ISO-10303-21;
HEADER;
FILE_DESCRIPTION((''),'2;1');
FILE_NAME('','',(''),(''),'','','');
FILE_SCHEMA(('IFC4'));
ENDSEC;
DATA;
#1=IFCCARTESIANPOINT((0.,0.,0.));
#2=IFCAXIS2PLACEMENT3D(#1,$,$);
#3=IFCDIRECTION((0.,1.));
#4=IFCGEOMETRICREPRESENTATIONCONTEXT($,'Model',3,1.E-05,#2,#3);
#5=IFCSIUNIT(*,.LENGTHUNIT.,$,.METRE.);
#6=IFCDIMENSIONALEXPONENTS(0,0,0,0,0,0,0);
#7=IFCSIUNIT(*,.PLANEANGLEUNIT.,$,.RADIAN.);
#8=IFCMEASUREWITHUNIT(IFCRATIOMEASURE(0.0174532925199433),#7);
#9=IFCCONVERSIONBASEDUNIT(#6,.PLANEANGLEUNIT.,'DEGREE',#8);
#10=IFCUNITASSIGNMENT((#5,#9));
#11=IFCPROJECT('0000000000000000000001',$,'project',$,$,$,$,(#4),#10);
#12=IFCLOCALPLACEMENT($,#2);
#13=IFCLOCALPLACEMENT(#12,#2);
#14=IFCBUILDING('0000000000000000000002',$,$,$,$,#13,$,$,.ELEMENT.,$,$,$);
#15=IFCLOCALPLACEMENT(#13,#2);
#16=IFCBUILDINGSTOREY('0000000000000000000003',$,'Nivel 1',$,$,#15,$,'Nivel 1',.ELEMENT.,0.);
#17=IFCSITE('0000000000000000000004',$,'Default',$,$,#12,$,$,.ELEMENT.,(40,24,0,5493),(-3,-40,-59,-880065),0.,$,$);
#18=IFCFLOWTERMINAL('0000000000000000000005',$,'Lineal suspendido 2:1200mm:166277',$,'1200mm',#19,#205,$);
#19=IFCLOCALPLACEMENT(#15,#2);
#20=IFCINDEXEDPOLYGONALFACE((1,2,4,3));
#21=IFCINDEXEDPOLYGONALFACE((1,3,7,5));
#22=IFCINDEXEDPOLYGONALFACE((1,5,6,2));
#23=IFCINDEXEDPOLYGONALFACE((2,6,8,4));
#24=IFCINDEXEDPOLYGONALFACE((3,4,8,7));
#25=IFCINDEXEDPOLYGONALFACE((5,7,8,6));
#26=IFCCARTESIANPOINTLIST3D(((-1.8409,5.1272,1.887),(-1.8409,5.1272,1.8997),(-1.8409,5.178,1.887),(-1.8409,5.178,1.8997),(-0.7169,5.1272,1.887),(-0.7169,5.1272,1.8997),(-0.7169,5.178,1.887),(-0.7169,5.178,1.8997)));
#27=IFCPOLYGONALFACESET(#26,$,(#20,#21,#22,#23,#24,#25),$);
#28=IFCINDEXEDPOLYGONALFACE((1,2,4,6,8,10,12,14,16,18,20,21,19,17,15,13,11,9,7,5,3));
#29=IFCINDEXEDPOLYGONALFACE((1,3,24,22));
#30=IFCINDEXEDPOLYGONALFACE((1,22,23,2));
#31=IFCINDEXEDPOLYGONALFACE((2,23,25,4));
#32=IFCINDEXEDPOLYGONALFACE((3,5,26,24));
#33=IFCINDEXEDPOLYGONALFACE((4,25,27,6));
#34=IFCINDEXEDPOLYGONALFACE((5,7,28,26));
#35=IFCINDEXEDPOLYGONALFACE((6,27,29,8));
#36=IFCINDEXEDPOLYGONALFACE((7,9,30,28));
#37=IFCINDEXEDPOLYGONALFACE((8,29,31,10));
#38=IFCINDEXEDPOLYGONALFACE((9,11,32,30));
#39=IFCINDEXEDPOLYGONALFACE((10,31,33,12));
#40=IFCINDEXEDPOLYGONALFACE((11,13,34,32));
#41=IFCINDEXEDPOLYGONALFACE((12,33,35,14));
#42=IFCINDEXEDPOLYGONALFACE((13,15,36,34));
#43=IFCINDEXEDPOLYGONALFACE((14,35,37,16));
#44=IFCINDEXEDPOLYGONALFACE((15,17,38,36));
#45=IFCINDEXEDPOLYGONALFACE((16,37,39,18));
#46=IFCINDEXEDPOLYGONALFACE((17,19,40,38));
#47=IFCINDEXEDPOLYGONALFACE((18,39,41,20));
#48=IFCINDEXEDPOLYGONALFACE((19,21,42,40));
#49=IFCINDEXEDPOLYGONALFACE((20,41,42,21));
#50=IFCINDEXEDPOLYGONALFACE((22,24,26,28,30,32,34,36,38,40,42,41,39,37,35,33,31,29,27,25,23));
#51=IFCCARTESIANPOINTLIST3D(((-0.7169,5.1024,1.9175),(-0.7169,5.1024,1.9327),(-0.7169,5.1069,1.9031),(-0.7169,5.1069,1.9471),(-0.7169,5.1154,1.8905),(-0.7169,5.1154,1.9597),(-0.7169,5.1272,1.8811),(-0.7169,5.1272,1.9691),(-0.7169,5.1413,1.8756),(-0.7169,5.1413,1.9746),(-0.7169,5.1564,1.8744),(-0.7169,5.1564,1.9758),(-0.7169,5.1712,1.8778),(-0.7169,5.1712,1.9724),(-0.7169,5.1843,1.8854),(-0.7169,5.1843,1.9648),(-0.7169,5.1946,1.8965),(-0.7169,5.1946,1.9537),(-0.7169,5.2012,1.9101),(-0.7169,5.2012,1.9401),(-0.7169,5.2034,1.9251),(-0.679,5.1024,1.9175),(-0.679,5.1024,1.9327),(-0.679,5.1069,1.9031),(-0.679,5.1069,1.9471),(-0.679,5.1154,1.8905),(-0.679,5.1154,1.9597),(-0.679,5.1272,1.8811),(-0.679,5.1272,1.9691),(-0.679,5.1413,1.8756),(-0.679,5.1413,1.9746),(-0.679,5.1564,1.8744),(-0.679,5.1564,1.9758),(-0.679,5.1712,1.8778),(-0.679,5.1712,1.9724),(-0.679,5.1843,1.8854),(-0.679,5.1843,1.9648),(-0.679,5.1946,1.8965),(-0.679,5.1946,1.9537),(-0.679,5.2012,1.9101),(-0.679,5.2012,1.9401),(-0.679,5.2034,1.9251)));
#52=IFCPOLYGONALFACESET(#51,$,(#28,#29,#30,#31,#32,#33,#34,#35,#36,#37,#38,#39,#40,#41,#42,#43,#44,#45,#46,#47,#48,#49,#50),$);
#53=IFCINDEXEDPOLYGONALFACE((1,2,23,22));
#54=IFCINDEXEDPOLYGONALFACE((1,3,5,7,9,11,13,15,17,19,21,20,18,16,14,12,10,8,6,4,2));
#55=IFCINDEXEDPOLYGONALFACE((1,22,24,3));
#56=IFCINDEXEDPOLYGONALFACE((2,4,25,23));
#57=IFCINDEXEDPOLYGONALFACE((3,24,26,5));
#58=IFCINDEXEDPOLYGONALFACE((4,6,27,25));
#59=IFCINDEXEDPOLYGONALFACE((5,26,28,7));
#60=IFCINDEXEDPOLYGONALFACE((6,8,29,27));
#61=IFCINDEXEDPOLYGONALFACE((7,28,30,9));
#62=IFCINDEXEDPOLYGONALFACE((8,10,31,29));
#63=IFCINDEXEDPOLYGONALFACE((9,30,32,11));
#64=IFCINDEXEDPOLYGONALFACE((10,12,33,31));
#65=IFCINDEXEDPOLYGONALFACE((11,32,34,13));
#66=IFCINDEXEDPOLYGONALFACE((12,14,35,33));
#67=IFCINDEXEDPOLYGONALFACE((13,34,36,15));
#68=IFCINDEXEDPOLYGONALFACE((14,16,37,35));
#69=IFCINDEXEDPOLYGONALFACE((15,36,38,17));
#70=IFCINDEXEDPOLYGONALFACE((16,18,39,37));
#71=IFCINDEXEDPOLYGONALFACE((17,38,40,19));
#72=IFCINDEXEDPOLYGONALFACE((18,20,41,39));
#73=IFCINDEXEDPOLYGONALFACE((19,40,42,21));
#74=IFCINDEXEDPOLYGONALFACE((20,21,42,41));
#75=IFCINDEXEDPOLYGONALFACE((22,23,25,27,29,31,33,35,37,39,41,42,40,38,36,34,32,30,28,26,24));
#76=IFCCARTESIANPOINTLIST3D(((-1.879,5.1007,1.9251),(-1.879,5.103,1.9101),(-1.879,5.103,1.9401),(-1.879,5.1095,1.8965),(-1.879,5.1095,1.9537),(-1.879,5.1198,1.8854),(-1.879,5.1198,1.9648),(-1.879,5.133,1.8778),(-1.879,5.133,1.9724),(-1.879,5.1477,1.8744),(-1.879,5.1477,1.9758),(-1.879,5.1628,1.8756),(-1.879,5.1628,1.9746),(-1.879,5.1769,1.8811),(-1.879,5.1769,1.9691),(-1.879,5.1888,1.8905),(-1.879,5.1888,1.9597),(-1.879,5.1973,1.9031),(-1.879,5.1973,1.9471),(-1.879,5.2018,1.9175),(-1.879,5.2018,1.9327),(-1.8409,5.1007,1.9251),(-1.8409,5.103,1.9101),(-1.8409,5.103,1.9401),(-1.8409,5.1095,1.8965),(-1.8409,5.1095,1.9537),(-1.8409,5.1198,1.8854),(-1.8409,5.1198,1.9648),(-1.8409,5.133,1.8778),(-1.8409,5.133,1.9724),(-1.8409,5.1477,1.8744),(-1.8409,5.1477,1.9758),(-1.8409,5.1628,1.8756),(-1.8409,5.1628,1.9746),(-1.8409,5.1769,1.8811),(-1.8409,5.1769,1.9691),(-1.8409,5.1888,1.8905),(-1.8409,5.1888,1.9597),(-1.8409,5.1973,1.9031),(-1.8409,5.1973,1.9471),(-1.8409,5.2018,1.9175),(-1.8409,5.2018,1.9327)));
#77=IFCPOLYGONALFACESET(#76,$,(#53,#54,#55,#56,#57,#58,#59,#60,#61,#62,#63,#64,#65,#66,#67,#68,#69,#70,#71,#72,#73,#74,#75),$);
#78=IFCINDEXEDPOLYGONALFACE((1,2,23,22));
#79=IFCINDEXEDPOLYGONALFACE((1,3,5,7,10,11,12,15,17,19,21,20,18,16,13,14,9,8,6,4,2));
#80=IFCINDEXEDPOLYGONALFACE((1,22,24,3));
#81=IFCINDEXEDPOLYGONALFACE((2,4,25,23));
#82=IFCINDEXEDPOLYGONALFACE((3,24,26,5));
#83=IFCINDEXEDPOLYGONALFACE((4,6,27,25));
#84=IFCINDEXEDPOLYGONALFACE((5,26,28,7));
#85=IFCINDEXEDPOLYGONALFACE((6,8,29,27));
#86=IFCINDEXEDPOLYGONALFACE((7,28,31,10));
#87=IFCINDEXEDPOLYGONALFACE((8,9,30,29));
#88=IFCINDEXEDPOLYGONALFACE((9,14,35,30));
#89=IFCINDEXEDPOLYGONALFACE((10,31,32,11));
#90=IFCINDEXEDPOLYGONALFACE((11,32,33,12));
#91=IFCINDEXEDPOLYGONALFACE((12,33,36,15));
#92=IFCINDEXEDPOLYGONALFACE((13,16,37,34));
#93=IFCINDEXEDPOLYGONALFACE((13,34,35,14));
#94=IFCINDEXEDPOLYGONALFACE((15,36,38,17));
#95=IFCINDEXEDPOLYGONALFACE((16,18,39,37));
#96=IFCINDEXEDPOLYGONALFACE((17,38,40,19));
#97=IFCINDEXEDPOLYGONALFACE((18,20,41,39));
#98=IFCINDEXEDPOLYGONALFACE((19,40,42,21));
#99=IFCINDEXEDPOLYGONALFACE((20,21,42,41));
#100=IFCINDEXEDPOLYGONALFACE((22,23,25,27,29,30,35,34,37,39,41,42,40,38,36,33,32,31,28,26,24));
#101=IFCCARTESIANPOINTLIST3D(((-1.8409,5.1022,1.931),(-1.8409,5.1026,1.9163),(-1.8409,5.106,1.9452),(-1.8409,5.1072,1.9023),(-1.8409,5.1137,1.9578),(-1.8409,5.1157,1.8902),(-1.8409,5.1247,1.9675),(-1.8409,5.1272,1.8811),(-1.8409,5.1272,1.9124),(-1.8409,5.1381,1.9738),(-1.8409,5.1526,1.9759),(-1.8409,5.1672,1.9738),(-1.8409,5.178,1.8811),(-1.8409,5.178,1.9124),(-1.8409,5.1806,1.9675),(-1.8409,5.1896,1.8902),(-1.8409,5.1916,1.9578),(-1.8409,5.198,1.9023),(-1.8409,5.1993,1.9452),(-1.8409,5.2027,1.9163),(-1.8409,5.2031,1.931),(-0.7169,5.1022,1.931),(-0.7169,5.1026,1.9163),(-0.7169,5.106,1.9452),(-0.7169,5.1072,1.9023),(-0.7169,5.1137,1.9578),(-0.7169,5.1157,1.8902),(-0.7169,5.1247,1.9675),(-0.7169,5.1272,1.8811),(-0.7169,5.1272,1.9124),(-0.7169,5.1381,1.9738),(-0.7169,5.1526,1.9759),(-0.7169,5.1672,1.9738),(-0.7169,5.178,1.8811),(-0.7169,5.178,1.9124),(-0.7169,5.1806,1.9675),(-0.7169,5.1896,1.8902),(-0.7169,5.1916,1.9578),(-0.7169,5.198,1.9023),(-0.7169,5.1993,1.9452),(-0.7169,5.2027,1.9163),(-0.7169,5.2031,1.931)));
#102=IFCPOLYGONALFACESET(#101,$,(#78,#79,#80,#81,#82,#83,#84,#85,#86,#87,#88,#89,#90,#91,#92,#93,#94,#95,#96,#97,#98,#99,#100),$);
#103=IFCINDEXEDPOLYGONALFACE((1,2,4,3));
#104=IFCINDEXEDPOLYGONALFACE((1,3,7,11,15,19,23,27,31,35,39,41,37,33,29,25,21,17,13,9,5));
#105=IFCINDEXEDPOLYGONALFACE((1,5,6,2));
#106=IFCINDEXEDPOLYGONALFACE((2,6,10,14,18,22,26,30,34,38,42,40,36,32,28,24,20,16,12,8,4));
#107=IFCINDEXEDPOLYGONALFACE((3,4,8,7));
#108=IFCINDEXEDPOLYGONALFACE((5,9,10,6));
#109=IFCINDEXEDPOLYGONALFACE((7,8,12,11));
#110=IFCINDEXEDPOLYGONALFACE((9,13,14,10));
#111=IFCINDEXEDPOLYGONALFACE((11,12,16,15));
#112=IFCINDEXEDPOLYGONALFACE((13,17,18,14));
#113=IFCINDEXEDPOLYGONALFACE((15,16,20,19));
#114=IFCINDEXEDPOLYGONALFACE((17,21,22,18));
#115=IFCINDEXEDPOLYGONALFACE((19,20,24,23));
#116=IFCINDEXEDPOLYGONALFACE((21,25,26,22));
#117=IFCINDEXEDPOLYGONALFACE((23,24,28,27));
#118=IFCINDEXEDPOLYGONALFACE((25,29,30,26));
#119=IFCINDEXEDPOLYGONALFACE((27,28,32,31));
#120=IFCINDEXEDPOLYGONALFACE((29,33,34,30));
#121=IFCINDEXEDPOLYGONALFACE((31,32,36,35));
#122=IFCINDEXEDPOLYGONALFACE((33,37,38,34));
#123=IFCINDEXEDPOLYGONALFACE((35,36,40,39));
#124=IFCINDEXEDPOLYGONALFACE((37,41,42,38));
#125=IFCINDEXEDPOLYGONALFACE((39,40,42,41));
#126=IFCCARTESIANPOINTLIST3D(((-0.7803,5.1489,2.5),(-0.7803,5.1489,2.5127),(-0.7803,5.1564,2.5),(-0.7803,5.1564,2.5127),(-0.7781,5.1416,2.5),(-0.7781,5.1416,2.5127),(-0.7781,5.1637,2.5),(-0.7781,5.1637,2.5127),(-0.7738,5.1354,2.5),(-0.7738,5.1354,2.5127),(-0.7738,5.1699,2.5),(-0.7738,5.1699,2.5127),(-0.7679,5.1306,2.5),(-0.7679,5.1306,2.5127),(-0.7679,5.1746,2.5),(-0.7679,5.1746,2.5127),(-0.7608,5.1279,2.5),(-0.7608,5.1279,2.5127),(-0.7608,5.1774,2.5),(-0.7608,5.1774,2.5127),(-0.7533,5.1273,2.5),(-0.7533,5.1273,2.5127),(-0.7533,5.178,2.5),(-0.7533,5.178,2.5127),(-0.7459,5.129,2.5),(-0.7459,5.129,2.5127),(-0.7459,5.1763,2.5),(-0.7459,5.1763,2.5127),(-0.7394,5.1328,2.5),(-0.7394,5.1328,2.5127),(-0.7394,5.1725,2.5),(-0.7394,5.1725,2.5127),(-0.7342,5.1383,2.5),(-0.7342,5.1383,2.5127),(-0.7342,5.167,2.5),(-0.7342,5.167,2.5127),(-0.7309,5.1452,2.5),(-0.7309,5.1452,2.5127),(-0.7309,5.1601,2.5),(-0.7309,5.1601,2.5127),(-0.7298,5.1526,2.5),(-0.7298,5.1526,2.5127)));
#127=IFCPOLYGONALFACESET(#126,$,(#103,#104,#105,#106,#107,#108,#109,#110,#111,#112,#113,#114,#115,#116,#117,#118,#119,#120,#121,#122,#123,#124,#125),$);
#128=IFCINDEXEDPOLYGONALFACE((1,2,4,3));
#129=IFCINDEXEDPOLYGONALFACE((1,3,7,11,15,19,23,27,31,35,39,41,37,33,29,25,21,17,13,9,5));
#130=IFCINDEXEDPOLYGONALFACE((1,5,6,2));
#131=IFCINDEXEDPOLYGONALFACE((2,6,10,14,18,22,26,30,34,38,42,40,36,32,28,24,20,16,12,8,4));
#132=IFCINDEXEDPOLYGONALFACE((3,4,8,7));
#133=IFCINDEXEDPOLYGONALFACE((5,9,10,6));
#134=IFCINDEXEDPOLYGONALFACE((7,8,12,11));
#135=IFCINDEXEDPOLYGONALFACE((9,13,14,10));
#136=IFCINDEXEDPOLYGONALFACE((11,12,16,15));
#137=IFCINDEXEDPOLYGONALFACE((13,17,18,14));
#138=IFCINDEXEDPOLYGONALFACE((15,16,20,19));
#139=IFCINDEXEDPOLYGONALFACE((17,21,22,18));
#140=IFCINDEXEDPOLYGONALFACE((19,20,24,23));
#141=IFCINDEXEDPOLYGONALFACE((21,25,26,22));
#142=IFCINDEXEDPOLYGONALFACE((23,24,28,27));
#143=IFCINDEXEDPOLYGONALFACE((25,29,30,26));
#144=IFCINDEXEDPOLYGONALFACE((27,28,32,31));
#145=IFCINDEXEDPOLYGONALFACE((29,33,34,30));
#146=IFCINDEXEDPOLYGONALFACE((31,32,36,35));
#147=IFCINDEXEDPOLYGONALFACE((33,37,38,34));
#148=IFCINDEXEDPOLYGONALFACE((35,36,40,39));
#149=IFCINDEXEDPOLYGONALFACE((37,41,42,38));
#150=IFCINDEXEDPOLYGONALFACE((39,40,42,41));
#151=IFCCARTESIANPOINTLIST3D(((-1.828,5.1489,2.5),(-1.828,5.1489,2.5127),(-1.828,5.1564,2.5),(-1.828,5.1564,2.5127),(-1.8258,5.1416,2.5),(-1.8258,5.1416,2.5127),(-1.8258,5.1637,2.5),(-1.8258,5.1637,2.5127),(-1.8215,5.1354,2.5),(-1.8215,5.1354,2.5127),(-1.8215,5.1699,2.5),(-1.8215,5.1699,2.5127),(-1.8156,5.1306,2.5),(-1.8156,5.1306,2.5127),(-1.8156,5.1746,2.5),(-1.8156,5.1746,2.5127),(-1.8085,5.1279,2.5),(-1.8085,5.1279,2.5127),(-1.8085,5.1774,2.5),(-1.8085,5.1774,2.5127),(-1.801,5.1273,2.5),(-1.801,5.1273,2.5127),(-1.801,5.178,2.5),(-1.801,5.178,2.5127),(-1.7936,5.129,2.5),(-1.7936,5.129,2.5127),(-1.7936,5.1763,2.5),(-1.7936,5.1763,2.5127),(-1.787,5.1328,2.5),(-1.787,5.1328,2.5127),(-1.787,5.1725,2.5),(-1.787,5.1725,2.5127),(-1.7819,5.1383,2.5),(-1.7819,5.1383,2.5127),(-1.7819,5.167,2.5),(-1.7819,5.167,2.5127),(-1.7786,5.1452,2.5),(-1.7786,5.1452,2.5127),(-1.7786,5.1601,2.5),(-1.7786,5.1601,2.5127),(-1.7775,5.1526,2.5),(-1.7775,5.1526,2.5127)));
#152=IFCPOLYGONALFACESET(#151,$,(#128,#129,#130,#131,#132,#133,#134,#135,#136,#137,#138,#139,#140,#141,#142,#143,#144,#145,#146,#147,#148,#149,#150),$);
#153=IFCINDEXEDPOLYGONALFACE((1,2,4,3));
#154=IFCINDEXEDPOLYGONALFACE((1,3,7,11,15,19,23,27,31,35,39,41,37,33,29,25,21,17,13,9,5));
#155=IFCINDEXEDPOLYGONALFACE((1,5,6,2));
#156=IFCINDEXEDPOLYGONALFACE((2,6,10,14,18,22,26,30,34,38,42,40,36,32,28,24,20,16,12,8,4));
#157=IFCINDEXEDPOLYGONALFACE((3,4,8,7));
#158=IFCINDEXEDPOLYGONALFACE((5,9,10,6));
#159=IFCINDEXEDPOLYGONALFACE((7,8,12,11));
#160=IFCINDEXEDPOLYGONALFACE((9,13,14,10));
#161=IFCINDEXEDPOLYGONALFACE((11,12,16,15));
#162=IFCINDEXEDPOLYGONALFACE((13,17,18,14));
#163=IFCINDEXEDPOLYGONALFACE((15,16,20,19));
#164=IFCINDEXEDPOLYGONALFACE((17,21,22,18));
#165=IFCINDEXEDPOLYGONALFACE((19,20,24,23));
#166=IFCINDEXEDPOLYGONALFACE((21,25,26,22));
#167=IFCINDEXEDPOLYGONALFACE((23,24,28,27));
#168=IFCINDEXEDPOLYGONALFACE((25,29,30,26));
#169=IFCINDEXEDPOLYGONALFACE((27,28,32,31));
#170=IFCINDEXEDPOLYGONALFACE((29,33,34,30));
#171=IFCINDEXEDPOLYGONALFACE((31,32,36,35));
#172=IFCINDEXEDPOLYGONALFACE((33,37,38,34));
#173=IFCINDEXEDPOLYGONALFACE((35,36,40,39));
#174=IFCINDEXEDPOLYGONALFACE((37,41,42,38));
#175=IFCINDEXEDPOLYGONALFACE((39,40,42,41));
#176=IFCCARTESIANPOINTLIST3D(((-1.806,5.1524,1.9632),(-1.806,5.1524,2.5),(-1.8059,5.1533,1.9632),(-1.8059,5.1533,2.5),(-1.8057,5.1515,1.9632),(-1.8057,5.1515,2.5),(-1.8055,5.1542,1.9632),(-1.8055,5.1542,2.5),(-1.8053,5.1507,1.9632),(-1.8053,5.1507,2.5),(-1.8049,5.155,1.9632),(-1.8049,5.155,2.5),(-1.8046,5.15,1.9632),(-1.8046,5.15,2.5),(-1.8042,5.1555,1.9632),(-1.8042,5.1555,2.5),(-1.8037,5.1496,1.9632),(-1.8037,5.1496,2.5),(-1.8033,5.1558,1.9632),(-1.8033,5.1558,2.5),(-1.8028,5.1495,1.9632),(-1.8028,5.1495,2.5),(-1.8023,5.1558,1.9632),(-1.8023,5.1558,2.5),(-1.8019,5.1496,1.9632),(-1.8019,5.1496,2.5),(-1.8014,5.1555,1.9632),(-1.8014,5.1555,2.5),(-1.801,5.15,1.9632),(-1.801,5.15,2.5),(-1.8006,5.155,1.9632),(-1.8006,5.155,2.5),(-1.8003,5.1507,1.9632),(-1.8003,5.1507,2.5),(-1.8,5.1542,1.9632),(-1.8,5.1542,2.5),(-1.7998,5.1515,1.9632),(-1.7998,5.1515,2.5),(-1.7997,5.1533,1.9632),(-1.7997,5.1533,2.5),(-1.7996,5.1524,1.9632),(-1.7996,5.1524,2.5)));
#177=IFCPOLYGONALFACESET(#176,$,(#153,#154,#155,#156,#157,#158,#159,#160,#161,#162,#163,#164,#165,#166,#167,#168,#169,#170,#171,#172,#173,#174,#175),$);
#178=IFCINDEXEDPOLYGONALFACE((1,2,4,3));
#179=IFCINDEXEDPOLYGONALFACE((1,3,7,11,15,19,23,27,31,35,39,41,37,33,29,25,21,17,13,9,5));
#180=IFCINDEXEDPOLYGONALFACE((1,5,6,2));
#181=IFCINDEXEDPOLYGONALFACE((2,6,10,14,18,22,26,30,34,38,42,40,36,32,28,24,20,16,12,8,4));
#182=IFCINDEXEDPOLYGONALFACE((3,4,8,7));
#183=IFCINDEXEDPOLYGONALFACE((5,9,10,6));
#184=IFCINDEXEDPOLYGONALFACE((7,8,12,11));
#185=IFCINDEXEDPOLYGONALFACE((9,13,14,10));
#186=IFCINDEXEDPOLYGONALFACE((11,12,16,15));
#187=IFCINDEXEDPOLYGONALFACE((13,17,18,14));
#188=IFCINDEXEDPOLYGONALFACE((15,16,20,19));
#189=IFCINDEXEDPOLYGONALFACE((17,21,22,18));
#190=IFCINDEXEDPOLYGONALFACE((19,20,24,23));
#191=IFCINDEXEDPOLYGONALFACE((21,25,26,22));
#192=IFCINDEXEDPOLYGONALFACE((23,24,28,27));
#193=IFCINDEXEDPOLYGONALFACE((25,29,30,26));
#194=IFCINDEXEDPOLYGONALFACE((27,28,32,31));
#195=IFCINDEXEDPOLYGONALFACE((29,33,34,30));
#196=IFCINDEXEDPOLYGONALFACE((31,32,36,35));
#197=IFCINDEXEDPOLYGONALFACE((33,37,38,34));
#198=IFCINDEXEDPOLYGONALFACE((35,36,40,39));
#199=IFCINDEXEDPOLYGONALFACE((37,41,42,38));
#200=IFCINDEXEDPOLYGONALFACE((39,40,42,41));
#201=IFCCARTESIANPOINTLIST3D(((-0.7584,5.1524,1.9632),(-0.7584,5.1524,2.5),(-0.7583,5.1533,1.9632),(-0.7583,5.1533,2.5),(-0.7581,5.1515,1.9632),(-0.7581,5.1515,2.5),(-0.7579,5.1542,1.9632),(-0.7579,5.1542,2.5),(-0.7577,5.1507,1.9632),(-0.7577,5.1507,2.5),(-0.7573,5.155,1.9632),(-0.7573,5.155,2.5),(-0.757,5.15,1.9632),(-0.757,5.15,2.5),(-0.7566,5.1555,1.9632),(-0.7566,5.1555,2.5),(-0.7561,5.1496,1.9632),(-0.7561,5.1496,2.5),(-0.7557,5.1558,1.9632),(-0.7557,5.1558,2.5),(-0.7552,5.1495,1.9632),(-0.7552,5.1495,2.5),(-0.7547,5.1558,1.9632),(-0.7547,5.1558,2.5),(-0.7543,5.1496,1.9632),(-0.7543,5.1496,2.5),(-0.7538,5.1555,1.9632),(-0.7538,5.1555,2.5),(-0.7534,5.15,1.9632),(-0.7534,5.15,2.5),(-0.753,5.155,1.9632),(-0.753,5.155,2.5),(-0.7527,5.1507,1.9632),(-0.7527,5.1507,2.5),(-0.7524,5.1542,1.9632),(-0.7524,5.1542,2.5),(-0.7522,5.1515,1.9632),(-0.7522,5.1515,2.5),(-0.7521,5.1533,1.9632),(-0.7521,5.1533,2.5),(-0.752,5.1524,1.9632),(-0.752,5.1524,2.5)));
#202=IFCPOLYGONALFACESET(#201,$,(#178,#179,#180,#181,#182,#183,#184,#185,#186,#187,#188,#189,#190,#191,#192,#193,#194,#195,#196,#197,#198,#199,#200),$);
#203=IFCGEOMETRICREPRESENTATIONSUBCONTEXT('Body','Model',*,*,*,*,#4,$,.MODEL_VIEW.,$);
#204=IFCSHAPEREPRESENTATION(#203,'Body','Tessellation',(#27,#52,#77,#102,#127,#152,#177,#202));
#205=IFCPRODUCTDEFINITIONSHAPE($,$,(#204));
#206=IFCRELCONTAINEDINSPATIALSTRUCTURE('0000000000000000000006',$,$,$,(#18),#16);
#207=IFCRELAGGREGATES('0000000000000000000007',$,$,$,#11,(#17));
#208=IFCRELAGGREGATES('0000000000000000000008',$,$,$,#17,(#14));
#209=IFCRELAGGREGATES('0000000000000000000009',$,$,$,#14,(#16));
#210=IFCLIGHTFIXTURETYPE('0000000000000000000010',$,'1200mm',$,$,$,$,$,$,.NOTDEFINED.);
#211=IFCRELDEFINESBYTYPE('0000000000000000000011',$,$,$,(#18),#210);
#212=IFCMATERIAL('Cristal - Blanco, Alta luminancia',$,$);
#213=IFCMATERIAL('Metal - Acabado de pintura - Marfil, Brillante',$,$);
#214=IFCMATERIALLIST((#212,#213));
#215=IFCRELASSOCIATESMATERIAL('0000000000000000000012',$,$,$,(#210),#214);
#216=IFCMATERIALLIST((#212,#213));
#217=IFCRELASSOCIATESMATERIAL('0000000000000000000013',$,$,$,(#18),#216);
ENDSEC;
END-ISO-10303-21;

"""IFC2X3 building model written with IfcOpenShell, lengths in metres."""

from ifc_helpers import new_model, entity, si_unit, converted_unit, direction, frame, frame_2d, origin, origin_2d_with_axis, place, context, subcontext, project, spatial, polyline, circle_curve, parameter, trimmed, segment, composite_curve, rectangle, circle, outline, extrude, source, transform, mapped, material, material_list, type_object, type_shapes, element, save


model = new_model("IFC2X3")

# Units and contexts
model_context = context("Model", 3, precision=1e-05, world=origin(), true_north=direction((0.0, 1.0)))
body_context = subcontext(model_context, "Body", "Model", "MODEL_VIEW")
ifc_project = project(units=[si_unit("LENGTHUNIT", "METRE"), converted_unit("PLANEANGLEUNIT", "DEGREE", entity("IfcRatioMeasure", 0.0174532925199433), si_unit("PLANEANGLEUNIT", "RADIAN"), dimensions=[0, 0, 0, 0, 0, 0, 0])], contexts=[model_context])

# Site, building, storey
site_placement = place(None, origin())
site = spatial("IfcSite", under=ifc_project, at=site_placement, Name="Default", CompositionType="ELEMENT", RefLatitude=(40, 24, 0, 5493), RefLongitude=(-3, -40, -59, -880065), RefElevation=0.0)
building_placement = place(site_placement, origin())
building = spatial("IfcBuilding", under=site, at=building_placement, CompositionType="ELEMENT")
storey_placement = place(building_placement, origin())
storey = spatial("IfcBuildingStorey", under=building, at=storey_placement, Name="Nivel 1", LongName="Nivel 1", CompositionType="ELEMENT", Elevation=0.0)

# Flow terminal
ifc_material_1 = material(Name="Cristal - Blanco, Alta luminancia")
ifc_material_2 = material(Name="Metal - Acabado de pintura - Marfil, Brillante")
ifc_material_list_1 = material_list([ifc_material_1, ifc_material_2])
ifc_material_list_2 = material_list([ifc_material_1, ifc_material_2])
light_fixture_type = type_object("IfcLightFixtureType", Name="1200mm", PredefinedType="NOTDEFINED", material=ifc_material_list_2)
shared_shape = source(origin(), body_context, "Body", "SweptSolid", [
    extrude(rectangle(XDim=1.124, YDim=0.0508, at=origin_2d_with_axis()), frame((0.0001, 0.0, 1.8127), z_axis=(0.0, 0.0, 1.0), x_axis=(-1.0, 0.0, 0.0)), (0.0, 0.0, 1.0), 0.0127),
    extrude(circle(Radius=0.0508, at=frame_2d((0.0, 0.0), x_axis=(1.0, 0.0))), frame((0.5621, 0.0, 1.8508), z_axis=(1.0, 0.0, 0.0), x_axis=(0.0, 1.0, 0.0)), (0.0, 0.0, 1.0), 0.0379),
    extrude(circle(Radius=0.0508, at=frame_2d((0.0, 0.0), x_axis=(1.0, 0.0))), frame((-0.6, -0.0011, 1.8508), z_axis=(1.0, 0.0, 0.0), x_axis=(0.0, -1.0, 0.0)), (0.0, 0.0, 1.0), 0.0381),
    extrude(outline(composite_curve([segment(trimmed(circle_curve(frame_2d((0.0125, 0.0), x_axis=(0.0, 1.0)), 0.0508), [parameter(120.0)], [parameter(270.0)], True, "PARAMETER"), True, "CONTINUOUS"), segment(trimmed(circle_curve(frame_2d((0.0125, 0.0), x_axis=(0.0, 1.0)), 0.0508), [parameter(270.0)], [parameter(60.0)], True, "PARAMETER"), True, "CONTINUOUS"), segment(polyline([(-0.0315, 0.0254), (-0.0002, 0.0254)]), True, "CONTINUOUS"), segment(polyline([(-0.0002, 0.0254), (-0.0002, -0.0254)]), True, "CONTINUOUS"), segment(polyline([(-0.0002, -0.0254), (-0.0315, -0.0254)]), True, "CONTINUOUS")], self_intersect=False)), frame((-0.5619, 0.0, 1.8383), z_axis=(-1.0, 0.0, 0.0), x_axis=(0.0, 0.0, 1.0)), (0.0, 0.0, -1.0), 1.124),
    extrude(circle(Radius=0.0254, at=frame_2d((0.0, 0.0), x_axis=(1.0, 0.0))), frame((0.5238, 0.0, 2.4257)), (0.0, 0.0, 1.0), 0.0127),
    extrude(circle(Radius=0.0254, at=frame_2d((0.0, 0.0), x_axis=(1.0, 0.0))), frame((-0.5239, 0.0, 2.4257)), (0.0, 0.0, 1.0), 0.0127),
    extrude(circle(Radius=0.0032, at=frame_2d((0.0, 0.0), x_axis=(1.0, 0.0))), frame((-0.5238, 0.0, 1.8889), z_axis=(0.0, 0.0, 1.0), x_axis=(0.0, -1.0, 0.0)), (0.0, 0.0, 1.0), 0.5368),
    extrude(circle(Radius=0.0032, at=frame_2d((0.0, 0.0), x_axis=(1.0, 0.0))), frame((0.5238, 0.0, 1.8889), z_axis=(0.0, 0.0, 1.0), x_axis=(0.0, -1.0, 0.0)), (0.0, 0.0, 1.0), 0.5368),
])
type_shapes(light_fixture_type, [shared_shape])
flow_terminal_1_placement = place(storey_placement, frame((-1.279, 5.1526, 0.0743)))
element("IfcFlowTerminal", 1, at=flow_terminal_1_placement, inside=storey, type_object=light_fixture_type, material=ifc_material_list_1, Name="Lineal suspendido 2:1200mm:166277", ObjectType="1200mm", context=body_context, shape_type="MappedRepresentation", body=[
    mapped(shared_shape, transform((0.0, 0.0, 0.0), scale=1.0)),
])

save(model, "model.ifc")
